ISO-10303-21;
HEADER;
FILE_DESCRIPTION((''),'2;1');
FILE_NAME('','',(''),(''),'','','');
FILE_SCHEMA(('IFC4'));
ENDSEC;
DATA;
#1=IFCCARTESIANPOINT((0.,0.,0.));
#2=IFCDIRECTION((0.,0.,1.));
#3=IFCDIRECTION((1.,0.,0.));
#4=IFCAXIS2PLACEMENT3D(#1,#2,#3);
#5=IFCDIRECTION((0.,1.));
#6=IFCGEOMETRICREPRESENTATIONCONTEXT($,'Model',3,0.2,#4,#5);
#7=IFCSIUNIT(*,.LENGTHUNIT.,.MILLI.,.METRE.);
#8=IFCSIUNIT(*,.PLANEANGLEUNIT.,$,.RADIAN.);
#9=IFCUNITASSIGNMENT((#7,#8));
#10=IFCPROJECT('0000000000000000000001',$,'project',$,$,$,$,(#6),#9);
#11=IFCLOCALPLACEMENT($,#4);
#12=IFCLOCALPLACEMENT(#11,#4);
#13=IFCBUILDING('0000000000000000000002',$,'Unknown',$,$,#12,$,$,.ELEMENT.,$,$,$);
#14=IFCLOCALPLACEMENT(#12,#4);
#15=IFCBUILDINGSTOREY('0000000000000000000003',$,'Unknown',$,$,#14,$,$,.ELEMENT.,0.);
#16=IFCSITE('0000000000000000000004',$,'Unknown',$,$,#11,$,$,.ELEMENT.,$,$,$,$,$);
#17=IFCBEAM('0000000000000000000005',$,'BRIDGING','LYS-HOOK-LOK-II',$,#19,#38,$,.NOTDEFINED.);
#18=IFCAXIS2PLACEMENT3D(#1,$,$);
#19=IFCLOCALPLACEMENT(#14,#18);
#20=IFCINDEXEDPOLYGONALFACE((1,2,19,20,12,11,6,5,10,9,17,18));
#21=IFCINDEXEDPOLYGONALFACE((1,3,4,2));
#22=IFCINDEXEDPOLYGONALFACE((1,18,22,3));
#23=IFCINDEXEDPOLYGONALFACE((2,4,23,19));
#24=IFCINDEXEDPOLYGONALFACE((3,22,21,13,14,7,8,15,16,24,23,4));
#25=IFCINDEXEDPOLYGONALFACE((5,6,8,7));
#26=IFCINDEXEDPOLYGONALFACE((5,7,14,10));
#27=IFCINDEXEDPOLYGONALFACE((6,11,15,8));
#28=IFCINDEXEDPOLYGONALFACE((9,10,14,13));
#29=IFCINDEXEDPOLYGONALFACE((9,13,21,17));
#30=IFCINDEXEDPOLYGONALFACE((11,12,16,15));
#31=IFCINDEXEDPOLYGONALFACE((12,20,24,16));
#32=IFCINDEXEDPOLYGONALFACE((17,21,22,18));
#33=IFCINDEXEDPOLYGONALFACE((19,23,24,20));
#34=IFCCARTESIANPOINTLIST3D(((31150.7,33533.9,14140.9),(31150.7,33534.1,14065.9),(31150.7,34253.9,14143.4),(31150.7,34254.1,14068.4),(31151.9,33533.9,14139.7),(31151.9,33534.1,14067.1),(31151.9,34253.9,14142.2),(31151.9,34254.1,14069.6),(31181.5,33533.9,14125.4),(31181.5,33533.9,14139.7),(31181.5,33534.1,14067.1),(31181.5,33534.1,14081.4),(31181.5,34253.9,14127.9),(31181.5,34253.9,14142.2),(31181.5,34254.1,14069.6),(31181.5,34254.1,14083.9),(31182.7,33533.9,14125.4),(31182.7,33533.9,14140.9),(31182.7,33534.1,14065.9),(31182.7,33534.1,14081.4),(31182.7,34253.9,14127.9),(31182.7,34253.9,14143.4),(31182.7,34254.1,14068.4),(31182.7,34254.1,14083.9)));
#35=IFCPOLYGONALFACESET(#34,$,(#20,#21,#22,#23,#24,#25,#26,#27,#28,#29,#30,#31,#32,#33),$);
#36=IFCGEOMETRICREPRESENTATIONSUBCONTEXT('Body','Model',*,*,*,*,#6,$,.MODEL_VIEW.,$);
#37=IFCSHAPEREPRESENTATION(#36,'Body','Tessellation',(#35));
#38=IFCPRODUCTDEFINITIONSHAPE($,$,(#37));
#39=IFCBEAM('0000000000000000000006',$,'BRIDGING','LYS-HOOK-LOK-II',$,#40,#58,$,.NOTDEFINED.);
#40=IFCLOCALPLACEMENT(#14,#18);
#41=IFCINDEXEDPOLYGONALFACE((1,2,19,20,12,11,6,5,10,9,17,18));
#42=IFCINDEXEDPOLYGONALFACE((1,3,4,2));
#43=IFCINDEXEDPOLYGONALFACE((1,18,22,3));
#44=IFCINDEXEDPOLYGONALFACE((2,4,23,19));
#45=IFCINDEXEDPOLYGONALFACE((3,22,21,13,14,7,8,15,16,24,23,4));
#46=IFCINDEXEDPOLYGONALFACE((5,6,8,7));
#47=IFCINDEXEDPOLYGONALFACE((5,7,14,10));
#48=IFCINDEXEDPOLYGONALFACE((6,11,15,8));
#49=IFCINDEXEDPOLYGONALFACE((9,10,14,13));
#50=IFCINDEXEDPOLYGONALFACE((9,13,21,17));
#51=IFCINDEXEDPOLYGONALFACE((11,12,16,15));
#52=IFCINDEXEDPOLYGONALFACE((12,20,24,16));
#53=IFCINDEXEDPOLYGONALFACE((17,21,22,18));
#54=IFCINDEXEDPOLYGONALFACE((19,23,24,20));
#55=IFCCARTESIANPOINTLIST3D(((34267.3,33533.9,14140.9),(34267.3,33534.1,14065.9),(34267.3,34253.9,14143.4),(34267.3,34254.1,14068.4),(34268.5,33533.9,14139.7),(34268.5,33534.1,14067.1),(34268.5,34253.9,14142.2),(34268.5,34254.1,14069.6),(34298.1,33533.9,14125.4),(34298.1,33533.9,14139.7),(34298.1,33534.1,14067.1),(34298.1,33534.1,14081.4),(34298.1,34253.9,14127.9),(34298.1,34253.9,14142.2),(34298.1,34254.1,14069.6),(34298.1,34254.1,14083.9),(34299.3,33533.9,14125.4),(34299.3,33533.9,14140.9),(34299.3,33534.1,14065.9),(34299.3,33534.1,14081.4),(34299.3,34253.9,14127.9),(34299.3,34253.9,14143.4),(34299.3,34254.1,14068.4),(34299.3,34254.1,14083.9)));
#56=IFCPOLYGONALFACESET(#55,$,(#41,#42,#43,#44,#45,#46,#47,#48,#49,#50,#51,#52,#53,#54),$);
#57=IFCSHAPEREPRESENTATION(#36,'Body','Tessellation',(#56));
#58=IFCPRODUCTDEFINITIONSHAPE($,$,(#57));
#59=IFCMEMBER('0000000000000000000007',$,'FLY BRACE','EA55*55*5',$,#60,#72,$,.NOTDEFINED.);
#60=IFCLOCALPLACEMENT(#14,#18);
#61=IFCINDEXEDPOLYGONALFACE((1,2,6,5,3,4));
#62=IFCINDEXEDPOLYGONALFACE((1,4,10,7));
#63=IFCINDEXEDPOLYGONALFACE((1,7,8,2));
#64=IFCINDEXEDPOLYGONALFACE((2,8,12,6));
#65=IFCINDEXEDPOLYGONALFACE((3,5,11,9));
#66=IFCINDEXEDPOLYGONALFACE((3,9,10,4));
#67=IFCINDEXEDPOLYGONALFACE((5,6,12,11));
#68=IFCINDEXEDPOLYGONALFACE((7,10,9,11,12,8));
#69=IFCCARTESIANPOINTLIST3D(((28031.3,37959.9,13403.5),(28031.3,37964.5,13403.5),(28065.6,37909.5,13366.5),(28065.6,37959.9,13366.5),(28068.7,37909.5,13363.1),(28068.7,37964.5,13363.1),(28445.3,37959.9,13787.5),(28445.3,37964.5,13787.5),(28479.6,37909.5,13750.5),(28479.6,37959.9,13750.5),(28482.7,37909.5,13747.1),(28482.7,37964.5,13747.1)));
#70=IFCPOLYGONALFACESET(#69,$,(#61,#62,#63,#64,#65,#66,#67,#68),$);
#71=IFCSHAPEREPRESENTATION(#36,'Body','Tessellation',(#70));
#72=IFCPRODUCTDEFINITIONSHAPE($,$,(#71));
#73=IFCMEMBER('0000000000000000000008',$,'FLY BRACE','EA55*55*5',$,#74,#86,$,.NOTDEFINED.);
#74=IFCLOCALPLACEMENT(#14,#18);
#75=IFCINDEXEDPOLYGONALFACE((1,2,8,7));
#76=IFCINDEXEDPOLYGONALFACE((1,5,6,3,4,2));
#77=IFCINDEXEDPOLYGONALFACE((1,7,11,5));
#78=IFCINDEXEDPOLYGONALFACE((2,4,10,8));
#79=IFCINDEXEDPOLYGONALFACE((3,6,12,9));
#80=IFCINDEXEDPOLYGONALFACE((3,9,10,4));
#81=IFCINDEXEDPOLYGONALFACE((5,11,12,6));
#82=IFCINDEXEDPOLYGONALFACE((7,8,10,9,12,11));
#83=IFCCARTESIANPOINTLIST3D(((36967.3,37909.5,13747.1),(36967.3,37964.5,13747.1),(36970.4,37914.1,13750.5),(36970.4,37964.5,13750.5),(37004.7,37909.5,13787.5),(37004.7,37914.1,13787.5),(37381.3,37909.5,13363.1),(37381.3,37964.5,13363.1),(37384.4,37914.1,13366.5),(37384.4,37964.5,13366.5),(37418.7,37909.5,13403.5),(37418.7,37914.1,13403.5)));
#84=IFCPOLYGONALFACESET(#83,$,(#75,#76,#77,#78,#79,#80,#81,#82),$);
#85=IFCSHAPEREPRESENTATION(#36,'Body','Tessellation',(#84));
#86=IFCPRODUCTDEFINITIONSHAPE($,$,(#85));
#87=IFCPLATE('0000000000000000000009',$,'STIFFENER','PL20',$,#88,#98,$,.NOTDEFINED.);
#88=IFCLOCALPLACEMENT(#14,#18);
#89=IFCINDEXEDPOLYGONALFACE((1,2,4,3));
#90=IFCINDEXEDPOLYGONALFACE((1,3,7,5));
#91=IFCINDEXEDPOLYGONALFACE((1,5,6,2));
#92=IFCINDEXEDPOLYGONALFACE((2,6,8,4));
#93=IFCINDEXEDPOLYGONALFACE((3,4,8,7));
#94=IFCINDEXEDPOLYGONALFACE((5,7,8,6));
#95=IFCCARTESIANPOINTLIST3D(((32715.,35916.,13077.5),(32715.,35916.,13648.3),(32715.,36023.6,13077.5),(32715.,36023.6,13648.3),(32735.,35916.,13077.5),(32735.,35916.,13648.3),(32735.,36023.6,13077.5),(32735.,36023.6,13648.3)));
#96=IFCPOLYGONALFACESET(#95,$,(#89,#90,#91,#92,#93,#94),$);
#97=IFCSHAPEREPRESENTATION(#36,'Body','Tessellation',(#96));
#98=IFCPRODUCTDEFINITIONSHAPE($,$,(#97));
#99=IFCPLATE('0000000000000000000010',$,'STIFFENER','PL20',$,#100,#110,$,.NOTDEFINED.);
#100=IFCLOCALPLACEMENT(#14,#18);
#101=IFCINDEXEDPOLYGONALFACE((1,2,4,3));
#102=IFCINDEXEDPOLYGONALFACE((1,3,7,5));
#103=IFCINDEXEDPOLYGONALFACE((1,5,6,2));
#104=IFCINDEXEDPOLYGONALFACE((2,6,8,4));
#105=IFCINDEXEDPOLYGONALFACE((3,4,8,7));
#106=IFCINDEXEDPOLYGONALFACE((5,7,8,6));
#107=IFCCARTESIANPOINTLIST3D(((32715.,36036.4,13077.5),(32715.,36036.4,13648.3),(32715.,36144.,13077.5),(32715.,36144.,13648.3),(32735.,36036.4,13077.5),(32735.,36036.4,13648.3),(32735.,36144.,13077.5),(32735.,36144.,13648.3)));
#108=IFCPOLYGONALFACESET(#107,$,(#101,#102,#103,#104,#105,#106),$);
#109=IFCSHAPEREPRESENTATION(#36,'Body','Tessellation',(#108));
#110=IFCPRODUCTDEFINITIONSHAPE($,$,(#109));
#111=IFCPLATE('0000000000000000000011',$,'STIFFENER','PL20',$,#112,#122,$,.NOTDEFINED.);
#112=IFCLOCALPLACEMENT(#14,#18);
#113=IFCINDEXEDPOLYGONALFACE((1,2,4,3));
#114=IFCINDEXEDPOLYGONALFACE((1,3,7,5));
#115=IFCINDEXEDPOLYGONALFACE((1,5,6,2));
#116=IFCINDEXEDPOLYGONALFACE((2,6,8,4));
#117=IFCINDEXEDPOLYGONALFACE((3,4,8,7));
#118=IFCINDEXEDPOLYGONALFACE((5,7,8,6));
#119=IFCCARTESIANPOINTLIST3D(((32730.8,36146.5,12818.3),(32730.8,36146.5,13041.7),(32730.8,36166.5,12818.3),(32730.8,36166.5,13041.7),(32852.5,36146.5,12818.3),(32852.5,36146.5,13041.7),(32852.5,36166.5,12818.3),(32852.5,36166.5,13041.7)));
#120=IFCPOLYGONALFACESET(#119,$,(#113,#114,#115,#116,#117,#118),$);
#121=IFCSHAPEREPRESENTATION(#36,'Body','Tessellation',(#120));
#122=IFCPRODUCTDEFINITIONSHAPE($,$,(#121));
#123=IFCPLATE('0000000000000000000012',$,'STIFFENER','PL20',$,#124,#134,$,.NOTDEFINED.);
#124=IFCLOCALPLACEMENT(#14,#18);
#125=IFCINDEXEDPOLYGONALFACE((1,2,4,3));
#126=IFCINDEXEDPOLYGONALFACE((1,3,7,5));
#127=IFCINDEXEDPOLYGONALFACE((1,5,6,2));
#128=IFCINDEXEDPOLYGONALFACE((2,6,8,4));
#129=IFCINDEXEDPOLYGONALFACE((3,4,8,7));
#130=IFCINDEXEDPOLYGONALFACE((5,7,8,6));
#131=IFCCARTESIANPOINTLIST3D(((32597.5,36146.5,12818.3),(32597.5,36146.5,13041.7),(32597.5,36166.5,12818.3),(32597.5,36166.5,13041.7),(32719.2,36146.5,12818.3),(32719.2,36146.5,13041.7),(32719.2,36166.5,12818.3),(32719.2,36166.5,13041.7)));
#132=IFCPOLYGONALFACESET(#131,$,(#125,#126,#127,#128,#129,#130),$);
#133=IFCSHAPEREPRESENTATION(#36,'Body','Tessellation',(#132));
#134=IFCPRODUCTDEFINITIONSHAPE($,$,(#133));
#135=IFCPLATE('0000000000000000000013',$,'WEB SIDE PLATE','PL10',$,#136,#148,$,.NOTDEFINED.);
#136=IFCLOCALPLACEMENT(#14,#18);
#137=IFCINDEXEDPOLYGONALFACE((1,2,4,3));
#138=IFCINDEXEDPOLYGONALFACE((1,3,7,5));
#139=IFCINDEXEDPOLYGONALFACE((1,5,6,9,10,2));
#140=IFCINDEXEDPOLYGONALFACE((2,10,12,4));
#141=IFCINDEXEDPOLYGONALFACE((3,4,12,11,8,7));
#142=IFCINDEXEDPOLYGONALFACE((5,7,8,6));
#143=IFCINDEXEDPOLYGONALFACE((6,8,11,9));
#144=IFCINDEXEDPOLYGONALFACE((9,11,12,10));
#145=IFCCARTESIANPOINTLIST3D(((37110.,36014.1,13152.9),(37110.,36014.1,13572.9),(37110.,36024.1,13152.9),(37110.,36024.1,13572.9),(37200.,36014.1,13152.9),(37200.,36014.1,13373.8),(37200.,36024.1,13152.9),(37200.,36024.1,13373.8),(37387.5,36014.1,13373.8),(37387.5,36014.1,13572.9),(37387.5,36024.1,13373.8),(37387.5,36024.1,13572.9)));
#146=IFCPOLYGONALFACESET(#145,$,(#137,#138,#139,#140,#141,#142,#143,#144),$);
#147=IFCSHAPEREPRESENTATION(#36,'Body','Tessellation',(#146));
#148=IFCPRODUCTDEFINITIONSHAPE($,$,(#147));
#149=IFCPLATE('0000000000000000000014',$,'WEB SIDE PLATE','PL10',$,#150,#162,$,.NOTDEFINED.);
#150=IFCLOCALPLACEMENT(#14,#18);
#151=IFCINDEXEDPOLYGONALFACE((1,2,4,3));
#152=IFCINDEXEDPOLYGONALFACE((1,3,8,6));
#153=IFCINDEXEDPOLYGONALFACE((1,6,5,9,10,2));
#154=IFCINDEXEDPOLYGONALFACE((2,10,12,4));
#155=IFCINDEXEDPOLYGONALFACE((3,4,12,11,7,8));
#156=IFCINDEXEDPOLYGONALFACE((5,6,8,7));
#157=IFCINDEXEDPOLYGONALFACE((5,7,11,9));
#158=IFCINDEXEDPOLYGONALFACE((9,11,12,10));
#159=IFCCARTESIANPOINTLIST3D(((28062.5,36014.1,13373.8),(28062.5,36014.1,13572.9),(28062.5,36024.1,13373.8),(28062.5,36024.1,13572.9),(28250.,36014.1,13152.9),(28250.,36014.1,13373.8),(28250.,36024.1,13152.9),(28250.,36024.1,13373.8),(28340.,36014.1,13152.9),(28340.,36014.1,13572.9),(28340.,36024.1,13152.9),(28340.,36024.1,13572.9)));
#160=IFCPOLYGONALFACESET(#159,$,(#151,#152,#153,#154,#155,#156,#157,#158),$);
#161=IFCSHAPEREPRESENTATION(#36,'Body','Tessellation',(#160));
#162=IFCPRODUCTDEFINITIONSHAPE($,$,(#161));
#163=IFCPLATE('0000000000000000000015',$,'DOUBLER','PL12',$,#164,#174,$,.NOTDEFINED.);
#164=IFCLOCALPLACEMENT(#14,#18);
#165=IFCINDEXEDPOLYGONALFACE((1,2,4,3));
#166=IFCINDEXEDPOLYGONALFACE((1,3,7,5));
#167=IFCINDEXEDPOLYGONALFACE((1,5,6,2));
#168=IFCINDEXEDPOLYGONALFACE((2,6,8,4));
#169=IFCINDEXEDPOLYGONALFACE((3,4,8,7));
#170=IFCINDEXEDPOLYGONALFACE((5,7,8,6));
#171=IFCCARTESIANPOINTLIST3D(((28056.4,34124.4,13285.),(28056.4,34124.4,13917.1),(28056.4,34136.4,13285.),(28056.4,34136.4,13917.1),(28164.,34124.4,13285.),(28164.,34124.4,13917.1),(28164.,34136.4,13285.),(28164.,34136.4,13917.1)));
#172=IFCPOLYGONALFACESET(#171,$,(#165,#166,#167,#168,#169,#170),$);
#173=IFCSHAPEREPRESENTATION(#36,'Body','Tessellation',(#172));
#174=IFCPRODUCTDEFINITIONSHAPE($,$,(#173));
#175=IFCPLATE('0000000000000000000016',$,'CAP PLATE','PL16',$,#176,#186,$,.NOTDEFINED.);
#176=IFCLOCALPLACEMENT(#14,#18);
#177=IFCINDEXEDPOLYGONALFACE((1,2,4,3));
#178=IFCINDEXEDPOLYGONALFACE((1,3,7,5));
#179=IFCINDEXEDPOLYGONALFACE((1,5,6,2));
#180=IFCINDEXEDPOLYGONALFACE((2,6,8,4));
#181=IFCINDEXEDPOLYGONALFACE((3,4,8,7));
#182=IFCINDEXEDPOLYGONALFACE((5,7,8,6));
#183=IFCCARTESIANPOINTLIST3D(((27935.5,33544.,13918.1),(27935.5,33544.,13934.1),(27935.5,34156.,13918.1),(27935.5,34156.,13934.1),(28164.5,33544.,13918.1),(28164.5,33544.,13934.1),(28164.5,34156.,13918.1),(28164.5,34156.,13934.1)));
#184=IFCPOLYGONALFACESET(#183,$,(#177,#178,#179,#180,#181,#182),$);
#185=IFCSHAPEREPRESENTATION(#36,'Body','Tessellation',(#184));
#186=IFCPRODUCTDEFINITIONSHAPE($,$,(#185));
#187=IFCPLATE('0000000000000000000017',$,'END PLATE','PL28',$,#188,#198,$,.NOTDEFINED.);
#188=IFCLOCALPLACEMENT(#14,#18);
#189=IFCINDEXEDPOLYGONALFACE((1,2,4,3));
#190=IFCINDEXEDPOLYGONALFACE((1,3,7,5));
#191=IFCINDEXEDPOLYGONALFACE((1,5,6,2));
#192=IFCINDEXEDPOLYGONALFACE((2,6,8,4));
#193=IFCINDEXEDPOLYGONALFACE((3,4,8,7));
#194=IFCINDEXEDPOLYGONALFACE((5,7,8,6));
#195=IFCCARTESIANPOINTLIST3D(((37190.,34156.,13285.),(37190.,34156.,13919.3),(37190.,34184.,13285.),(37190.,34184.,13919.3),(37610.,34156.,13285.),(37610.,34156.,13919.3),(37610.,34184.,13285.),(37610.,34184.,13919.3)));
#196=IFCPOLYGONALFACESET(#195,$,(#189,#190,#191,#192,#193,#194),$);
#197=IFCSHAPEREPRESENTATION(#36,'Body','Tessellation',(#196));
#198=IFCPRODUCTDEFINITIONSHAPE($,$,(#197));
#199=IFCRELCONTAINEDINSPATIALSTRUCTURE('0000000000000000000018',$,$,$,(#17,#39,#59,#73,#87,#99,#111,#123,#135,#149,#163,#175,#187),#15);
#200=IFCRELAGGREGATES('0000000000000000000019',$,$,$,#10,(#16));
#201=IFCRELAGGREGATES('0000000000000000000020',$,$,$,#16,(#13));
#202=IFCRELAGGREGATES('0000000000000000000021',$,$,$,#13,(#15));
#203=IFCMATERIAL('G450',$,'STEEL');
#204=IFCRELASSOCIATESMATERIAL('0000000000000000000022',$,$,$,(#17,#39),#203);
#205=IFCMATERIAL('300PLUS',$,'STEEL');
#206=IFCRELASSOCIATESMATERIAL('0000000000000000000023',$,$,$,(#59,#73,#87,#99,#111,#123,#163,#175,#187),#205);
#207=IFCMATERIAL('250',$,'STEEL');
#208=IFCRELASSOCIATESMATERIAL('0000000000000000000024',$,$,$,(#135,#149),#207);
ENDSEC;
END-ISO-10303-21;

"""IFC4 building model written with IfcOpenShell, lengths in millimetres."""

from ifc_helpers import new_model, si_unit, direction, frame, origin_with_axes, place, context, subcontext, project, spatial, line, indexed_curve, outline, extrude, material, element, save


model = new_model("IFC4")

# Units and contexts
model_context = context("Model", 3, precision=0.2, world=origin_with_axes(), true_north=direction((0.0, 1.0)))
body_context = subcontext(model_context, "Body", "Model", "MODEL_VIEW")
ifc_project = project(units=[si_unit("LENGTHUNIT", "METRE", prefix="MILLI"), si_unit("PLANEANGLEUNIT", "RADIAN")], contexts=[model_context])

# Site, building, storey
site_placement = place(None, origin_with_axes())
site = spatial("IfcSite", under=ifc_project, at=site_placement, Name="Unknown", CompositionType="ELEMENT")
building_placement = place(site_placement, origin_with_axes())
building = spatial("IfcBuilding", under=site, at=building_placement, Name="Unknown", CompositionType="ELEMENT")
storey_placement = place(building_placement, origin_with_axes())
storey = spatial("IfcBuildingStorey", under=building, at=storey_placement, Name="Unknown", CompositionType="ELEMENT", Elevation=0.0)

# Beams
ifc_material_1 = material(Name="300PLUS", Category="STEEL")
ifc_material_2 = material(Name="G450", Category="STEEL")
for number, where, z_axis, x_axis, name in (
    (1, (31166.7, 33534.0, 14103.4), (1.0, 0.0, 0.0), (0.0, 0.999994, 0.003472), "BRIDGING"),
    (2, (34283.3, 33534.0, 14103.4), (1.0, 0.0, 0.0), (0.0, 0.999994, 0.003472), "BRIDGING"),
):
    element("IfcBeam", number, at=place(storey_placement, frame(where, z_axis=z_axis, x_axis=x_axis)), inside=storey, material=ifc_material_2, Name=name, Description="LYS-HOOK-LOK-II", PredefinedType="NOTDEFINED", context=body_context, shape_type="SolidModel", body=[
        extrude(outline(indexed_curve([(16.0, -37.5), (16.0, -22.0), (14.8, -22.0), (14.8, -36.3), (-14.8, -36.3), (-14.8, 36.3), (14.8, 36.3), (14.8, 22.0), (16.0, 22.0), (16.0, 37.5), (-16.0, 37.5), (-16.0, -37.5)], segments=[line(1, 2, 3, 4, 5, 6, 7, 8, 9, 10, 11, 12, 1)])), frame((0.0, 0.0, 0.0), z_axis=(-1.0, 0.0, 0.0), x_axis=(0.0, 0.0, 1.0)), (0.0, 0.0, -1.0), 720.0),
    ])

# Members
for number, where, z_axis, x_axis, name in (
    (3, (28464.0, 37937.0, 13767.3), (-0.680043, 0.0, 0.733172), (-0.733172, 0.0, -0.680043), "FLY BRACE"),
    (4, (36986.0, 37937.0, 13767.3), (0.680043, 0.0, 0.733172), (0.733172, 0.0, -0.680043), "FLY BRACE"),
):
    element("IfcMember", number, at=place(storey_placement, frame(where, z_axis=z_axis, x_axis=x_axis)), inside=storey, material=ifc_material_1, Name=name, Description="EA55*55*5", PredefinedType="NOTDEFINED", context=body_context, shape_type="SolidModel", body=[
        extrude(outline(indexed_curve([(-27.5, -27.5), (27.5, -27.5), (27.5, -22.9), (-22.9, -22.9), (-22.9, 27.5), (-27.5, 27.5)], segments=[line(1, 2, 3, 4, 5, 6, 1)])), frame((0.0, 0.0, 0.0), z_axis=(-1.0, 0.0, 0.0), x_axis=(0.0, 0.0, 1.0)), (0.0, 0.0, -1.0), 564.7),
    ])

# Plates
for number, where, z_axis, x_axis, name in (
    (5, (32725.0, 36023.6, 13077.5), (1.0, 0.0, 0.0), (0.0, 0.0, 1.0), "STIFFENER"),
    (6, (32725.0, 36144.0, 13077.5), (1.0, 0.0, 0.0), (0.0, 0.0, 1.0), "STIFFENER"),
):
    element("IfcPlate", number, at=place(storey_placement, frame(where, z_axis=z_axis, x_axis=x_axis)), inside=storey, material=ifc_material_1, Name=name, Description="PL20", PredefinedType="NOTDEFINED", context=body_context, shape_type="SolidModel", body=[
        extrude(outline(indexed_curve([(0.0, 0.0), (570.8, 0.0), (570.8, 107.6), (0.0, 107.6)], segments=[line(1, 2, 3, 4, 1)])), frame((0.0, 0.0, 10.0), z_axis=(0.0, 0.0, 1.0), x_axis=(1.0, 0.0, 0.0)), (0.0, 0.0, -1.0), 20.0),
    ])
for number, where, z_axis, x_axis, name in (
    (7, (32730.8, 36156.5, 12818.3), (0.0, 1.0, 0.0), (0.0, 0.0, 1.0), "STIFFENER"),
    (8, (32597.5, 36156.5, 12818.3), (0.0, 1.0, 0.0), (0.0, 0.0, 1.0), "STIFFENER"),
):
    element("IfcPlate", number, at=place(storey_placement, frame(where, z_axis=z_axis, x_axis=x_axis)), inside=storey, material=ifc_material_1, Name=name, Description="PL20", PredefinedType="NOTDEFINED", context=body_context, shape_type="SolidModel", body=[
        extrude(outline(indexed_curve([(0.0, 0.0), (223.4, 0.0), (223.4, 121.7), (0.0, 121.7)], segments=[line(1, 2, 3, 4, 1)])), frame((0.0, 0.0, 10.0), z_axis=(0.0, 0.0, 1.0), x_axis=(1.0, 0.0, 0.0)), (0.0, 0.0, -1.0), 20.0),
    ])
ifc_material_3 = material(Name="250", Category="STEEL")
plate_1_placement = place(storey_placement, frame((37200.0, 36019.1, 13152.9), z_axis=(0.0, -1.0, 0.0), x_axis=(0.0, 0.0, 1.0)))
element("IfcPlate", 9, at=plate_1_placement, inside=storey, material=ifc_material_3, Name="WEB SIDE PLATE", Description="PL10", PredefinedType="NOTDEFINED", context=body_context, shape_type="SolidModel", body=[
    extrude(outline(indexed_curve([(0.0, 0.0), (220.9, 0.0), (220.9, -187.5), (420.0, -187.5), (420.0, 90.0), (0.0, 90.0)], segments=[line(1, 2, 3, 4, 5, 6, 1)])), frame((0.0, 0.0, 5.0), z_axis=(0.0, 0.0, 1.0), x_axis=(1.0, 0.0, 0.0)), (0.0, 0.0, -1.0), 10.0),
])
plate_2_placement = place(storey_placement, frame((28340.0, 36019.1, 13152.9), z_axis=(0.0, -1.0, 0.0), x_axis=(0.0, 0.0, 1.0)))
element("IfcPlate", 10, at=plate_2_placement, inside=storey, material=ifc_material_3, Name="WEB SIDE PLATE", Description="PL10", PredefinedType="NOTDEFINED", context=body_context, shape_type="SolidModel", body=[
    extrude(outline(indexed_curve([(0.0, 0.0), (420.0, 0.0), (420.0, 277.5), (220.9, 277.5), (220.9, 90.0), (0.0, 90.0)], segments=[line(1, 2, 3, 4, 5, 6, 1)])), frame((0.0, 0.0, 5.0), z_axis=(0.0, 0.0, 1.0), x_axis=(1.0, 0.0, 0.0)), (0.0, 0.0, -1.0), 10.0),
])
plate_3_placement = place(storey_placement, frame((28164.0, 34130.4, 13917.1), z_axis=(0.0, -1.0, 0.0), x_axis=(-1.0, 0.0, 0.0)))
element("IfcPlate", 11, at=plate_3_placement, inside=storey, material=ifc_material_1, Name="DOUBLER", Description="PL12", PredefinedType="NOTDEFINED", context=body_context, shape_type="SolidModel", body=[
    extrude(outline(indexed_curve([(0.0, 0.0), (107.6, 0.0), (107.6, 632.1), (0.0, 632.1)], segments=[line(1, 2, 3, 4, 1)])), frame((0.0, 0.0, 6.0), z_axis=(0.0, 0.0, 1.0), x_axis=(1.0, 0.0, 0.0)), (0.0, 0.0, -1.0), 12.0),
])
plate_4_placement = place(storey_placement, frame((28164.5, 33544.0, 13926.1), z_axis=(0.0, 0.0, 1.0), x_axis=(0.0, 1.0, 0.0)))
element("IfcPlate", 12, at=plate_4_placement, inside=storey, material=ifc_material_1, Name="CAP PLATE", Description="PL16", PredefinedType="NOTDEFINED", context=body_context, shape_type="SolidModel", body=[
    extrude(outline(indexed_curve([(0.0, 0.0), (612.0, 0.0), (612.0, 229.0), (0.0, 229.0)], segments=[line(1, 2, 3, 4, 1)])), frame((0.0, 0.0, 8.0), z_axis=(0.0, 0.0, 1.0), x_axis=(1.0, 0.0, 0.0)), (0.0, 0.0, -1.0), 16.0),
])
plate_5_placement = place(storey_placement, frame((37190.0, 34170.0, 13919.3), z_axis=(0.0, 1.0, 0.0), x_axis=(1.0, 0.0, 0.0)))
element("IfcPlate", 13, at=plate_5_placement, inside=storey, material=ifc_material_1, Name="END PLATE", Description="PL28", PredefinedType="NOTDEFINED", context=body_context, shape_type="SolidModel", body=[
    extrude(outline(indexed_curve([(0.0, 0.0), (420.0, 0.0), (420.0, 634.3), (0.0, 634.3)], segments=[line(1, 2, 3, 4, 1)])), frame((0.0, 0.0, 14.0), z_axis=(0.0, 0.0, 1.0), x_axis=(1.0, 0.0, 0.0)), (0.0, 0.0, -1.0), 28.0),
])

save(model, "model.ifc")
